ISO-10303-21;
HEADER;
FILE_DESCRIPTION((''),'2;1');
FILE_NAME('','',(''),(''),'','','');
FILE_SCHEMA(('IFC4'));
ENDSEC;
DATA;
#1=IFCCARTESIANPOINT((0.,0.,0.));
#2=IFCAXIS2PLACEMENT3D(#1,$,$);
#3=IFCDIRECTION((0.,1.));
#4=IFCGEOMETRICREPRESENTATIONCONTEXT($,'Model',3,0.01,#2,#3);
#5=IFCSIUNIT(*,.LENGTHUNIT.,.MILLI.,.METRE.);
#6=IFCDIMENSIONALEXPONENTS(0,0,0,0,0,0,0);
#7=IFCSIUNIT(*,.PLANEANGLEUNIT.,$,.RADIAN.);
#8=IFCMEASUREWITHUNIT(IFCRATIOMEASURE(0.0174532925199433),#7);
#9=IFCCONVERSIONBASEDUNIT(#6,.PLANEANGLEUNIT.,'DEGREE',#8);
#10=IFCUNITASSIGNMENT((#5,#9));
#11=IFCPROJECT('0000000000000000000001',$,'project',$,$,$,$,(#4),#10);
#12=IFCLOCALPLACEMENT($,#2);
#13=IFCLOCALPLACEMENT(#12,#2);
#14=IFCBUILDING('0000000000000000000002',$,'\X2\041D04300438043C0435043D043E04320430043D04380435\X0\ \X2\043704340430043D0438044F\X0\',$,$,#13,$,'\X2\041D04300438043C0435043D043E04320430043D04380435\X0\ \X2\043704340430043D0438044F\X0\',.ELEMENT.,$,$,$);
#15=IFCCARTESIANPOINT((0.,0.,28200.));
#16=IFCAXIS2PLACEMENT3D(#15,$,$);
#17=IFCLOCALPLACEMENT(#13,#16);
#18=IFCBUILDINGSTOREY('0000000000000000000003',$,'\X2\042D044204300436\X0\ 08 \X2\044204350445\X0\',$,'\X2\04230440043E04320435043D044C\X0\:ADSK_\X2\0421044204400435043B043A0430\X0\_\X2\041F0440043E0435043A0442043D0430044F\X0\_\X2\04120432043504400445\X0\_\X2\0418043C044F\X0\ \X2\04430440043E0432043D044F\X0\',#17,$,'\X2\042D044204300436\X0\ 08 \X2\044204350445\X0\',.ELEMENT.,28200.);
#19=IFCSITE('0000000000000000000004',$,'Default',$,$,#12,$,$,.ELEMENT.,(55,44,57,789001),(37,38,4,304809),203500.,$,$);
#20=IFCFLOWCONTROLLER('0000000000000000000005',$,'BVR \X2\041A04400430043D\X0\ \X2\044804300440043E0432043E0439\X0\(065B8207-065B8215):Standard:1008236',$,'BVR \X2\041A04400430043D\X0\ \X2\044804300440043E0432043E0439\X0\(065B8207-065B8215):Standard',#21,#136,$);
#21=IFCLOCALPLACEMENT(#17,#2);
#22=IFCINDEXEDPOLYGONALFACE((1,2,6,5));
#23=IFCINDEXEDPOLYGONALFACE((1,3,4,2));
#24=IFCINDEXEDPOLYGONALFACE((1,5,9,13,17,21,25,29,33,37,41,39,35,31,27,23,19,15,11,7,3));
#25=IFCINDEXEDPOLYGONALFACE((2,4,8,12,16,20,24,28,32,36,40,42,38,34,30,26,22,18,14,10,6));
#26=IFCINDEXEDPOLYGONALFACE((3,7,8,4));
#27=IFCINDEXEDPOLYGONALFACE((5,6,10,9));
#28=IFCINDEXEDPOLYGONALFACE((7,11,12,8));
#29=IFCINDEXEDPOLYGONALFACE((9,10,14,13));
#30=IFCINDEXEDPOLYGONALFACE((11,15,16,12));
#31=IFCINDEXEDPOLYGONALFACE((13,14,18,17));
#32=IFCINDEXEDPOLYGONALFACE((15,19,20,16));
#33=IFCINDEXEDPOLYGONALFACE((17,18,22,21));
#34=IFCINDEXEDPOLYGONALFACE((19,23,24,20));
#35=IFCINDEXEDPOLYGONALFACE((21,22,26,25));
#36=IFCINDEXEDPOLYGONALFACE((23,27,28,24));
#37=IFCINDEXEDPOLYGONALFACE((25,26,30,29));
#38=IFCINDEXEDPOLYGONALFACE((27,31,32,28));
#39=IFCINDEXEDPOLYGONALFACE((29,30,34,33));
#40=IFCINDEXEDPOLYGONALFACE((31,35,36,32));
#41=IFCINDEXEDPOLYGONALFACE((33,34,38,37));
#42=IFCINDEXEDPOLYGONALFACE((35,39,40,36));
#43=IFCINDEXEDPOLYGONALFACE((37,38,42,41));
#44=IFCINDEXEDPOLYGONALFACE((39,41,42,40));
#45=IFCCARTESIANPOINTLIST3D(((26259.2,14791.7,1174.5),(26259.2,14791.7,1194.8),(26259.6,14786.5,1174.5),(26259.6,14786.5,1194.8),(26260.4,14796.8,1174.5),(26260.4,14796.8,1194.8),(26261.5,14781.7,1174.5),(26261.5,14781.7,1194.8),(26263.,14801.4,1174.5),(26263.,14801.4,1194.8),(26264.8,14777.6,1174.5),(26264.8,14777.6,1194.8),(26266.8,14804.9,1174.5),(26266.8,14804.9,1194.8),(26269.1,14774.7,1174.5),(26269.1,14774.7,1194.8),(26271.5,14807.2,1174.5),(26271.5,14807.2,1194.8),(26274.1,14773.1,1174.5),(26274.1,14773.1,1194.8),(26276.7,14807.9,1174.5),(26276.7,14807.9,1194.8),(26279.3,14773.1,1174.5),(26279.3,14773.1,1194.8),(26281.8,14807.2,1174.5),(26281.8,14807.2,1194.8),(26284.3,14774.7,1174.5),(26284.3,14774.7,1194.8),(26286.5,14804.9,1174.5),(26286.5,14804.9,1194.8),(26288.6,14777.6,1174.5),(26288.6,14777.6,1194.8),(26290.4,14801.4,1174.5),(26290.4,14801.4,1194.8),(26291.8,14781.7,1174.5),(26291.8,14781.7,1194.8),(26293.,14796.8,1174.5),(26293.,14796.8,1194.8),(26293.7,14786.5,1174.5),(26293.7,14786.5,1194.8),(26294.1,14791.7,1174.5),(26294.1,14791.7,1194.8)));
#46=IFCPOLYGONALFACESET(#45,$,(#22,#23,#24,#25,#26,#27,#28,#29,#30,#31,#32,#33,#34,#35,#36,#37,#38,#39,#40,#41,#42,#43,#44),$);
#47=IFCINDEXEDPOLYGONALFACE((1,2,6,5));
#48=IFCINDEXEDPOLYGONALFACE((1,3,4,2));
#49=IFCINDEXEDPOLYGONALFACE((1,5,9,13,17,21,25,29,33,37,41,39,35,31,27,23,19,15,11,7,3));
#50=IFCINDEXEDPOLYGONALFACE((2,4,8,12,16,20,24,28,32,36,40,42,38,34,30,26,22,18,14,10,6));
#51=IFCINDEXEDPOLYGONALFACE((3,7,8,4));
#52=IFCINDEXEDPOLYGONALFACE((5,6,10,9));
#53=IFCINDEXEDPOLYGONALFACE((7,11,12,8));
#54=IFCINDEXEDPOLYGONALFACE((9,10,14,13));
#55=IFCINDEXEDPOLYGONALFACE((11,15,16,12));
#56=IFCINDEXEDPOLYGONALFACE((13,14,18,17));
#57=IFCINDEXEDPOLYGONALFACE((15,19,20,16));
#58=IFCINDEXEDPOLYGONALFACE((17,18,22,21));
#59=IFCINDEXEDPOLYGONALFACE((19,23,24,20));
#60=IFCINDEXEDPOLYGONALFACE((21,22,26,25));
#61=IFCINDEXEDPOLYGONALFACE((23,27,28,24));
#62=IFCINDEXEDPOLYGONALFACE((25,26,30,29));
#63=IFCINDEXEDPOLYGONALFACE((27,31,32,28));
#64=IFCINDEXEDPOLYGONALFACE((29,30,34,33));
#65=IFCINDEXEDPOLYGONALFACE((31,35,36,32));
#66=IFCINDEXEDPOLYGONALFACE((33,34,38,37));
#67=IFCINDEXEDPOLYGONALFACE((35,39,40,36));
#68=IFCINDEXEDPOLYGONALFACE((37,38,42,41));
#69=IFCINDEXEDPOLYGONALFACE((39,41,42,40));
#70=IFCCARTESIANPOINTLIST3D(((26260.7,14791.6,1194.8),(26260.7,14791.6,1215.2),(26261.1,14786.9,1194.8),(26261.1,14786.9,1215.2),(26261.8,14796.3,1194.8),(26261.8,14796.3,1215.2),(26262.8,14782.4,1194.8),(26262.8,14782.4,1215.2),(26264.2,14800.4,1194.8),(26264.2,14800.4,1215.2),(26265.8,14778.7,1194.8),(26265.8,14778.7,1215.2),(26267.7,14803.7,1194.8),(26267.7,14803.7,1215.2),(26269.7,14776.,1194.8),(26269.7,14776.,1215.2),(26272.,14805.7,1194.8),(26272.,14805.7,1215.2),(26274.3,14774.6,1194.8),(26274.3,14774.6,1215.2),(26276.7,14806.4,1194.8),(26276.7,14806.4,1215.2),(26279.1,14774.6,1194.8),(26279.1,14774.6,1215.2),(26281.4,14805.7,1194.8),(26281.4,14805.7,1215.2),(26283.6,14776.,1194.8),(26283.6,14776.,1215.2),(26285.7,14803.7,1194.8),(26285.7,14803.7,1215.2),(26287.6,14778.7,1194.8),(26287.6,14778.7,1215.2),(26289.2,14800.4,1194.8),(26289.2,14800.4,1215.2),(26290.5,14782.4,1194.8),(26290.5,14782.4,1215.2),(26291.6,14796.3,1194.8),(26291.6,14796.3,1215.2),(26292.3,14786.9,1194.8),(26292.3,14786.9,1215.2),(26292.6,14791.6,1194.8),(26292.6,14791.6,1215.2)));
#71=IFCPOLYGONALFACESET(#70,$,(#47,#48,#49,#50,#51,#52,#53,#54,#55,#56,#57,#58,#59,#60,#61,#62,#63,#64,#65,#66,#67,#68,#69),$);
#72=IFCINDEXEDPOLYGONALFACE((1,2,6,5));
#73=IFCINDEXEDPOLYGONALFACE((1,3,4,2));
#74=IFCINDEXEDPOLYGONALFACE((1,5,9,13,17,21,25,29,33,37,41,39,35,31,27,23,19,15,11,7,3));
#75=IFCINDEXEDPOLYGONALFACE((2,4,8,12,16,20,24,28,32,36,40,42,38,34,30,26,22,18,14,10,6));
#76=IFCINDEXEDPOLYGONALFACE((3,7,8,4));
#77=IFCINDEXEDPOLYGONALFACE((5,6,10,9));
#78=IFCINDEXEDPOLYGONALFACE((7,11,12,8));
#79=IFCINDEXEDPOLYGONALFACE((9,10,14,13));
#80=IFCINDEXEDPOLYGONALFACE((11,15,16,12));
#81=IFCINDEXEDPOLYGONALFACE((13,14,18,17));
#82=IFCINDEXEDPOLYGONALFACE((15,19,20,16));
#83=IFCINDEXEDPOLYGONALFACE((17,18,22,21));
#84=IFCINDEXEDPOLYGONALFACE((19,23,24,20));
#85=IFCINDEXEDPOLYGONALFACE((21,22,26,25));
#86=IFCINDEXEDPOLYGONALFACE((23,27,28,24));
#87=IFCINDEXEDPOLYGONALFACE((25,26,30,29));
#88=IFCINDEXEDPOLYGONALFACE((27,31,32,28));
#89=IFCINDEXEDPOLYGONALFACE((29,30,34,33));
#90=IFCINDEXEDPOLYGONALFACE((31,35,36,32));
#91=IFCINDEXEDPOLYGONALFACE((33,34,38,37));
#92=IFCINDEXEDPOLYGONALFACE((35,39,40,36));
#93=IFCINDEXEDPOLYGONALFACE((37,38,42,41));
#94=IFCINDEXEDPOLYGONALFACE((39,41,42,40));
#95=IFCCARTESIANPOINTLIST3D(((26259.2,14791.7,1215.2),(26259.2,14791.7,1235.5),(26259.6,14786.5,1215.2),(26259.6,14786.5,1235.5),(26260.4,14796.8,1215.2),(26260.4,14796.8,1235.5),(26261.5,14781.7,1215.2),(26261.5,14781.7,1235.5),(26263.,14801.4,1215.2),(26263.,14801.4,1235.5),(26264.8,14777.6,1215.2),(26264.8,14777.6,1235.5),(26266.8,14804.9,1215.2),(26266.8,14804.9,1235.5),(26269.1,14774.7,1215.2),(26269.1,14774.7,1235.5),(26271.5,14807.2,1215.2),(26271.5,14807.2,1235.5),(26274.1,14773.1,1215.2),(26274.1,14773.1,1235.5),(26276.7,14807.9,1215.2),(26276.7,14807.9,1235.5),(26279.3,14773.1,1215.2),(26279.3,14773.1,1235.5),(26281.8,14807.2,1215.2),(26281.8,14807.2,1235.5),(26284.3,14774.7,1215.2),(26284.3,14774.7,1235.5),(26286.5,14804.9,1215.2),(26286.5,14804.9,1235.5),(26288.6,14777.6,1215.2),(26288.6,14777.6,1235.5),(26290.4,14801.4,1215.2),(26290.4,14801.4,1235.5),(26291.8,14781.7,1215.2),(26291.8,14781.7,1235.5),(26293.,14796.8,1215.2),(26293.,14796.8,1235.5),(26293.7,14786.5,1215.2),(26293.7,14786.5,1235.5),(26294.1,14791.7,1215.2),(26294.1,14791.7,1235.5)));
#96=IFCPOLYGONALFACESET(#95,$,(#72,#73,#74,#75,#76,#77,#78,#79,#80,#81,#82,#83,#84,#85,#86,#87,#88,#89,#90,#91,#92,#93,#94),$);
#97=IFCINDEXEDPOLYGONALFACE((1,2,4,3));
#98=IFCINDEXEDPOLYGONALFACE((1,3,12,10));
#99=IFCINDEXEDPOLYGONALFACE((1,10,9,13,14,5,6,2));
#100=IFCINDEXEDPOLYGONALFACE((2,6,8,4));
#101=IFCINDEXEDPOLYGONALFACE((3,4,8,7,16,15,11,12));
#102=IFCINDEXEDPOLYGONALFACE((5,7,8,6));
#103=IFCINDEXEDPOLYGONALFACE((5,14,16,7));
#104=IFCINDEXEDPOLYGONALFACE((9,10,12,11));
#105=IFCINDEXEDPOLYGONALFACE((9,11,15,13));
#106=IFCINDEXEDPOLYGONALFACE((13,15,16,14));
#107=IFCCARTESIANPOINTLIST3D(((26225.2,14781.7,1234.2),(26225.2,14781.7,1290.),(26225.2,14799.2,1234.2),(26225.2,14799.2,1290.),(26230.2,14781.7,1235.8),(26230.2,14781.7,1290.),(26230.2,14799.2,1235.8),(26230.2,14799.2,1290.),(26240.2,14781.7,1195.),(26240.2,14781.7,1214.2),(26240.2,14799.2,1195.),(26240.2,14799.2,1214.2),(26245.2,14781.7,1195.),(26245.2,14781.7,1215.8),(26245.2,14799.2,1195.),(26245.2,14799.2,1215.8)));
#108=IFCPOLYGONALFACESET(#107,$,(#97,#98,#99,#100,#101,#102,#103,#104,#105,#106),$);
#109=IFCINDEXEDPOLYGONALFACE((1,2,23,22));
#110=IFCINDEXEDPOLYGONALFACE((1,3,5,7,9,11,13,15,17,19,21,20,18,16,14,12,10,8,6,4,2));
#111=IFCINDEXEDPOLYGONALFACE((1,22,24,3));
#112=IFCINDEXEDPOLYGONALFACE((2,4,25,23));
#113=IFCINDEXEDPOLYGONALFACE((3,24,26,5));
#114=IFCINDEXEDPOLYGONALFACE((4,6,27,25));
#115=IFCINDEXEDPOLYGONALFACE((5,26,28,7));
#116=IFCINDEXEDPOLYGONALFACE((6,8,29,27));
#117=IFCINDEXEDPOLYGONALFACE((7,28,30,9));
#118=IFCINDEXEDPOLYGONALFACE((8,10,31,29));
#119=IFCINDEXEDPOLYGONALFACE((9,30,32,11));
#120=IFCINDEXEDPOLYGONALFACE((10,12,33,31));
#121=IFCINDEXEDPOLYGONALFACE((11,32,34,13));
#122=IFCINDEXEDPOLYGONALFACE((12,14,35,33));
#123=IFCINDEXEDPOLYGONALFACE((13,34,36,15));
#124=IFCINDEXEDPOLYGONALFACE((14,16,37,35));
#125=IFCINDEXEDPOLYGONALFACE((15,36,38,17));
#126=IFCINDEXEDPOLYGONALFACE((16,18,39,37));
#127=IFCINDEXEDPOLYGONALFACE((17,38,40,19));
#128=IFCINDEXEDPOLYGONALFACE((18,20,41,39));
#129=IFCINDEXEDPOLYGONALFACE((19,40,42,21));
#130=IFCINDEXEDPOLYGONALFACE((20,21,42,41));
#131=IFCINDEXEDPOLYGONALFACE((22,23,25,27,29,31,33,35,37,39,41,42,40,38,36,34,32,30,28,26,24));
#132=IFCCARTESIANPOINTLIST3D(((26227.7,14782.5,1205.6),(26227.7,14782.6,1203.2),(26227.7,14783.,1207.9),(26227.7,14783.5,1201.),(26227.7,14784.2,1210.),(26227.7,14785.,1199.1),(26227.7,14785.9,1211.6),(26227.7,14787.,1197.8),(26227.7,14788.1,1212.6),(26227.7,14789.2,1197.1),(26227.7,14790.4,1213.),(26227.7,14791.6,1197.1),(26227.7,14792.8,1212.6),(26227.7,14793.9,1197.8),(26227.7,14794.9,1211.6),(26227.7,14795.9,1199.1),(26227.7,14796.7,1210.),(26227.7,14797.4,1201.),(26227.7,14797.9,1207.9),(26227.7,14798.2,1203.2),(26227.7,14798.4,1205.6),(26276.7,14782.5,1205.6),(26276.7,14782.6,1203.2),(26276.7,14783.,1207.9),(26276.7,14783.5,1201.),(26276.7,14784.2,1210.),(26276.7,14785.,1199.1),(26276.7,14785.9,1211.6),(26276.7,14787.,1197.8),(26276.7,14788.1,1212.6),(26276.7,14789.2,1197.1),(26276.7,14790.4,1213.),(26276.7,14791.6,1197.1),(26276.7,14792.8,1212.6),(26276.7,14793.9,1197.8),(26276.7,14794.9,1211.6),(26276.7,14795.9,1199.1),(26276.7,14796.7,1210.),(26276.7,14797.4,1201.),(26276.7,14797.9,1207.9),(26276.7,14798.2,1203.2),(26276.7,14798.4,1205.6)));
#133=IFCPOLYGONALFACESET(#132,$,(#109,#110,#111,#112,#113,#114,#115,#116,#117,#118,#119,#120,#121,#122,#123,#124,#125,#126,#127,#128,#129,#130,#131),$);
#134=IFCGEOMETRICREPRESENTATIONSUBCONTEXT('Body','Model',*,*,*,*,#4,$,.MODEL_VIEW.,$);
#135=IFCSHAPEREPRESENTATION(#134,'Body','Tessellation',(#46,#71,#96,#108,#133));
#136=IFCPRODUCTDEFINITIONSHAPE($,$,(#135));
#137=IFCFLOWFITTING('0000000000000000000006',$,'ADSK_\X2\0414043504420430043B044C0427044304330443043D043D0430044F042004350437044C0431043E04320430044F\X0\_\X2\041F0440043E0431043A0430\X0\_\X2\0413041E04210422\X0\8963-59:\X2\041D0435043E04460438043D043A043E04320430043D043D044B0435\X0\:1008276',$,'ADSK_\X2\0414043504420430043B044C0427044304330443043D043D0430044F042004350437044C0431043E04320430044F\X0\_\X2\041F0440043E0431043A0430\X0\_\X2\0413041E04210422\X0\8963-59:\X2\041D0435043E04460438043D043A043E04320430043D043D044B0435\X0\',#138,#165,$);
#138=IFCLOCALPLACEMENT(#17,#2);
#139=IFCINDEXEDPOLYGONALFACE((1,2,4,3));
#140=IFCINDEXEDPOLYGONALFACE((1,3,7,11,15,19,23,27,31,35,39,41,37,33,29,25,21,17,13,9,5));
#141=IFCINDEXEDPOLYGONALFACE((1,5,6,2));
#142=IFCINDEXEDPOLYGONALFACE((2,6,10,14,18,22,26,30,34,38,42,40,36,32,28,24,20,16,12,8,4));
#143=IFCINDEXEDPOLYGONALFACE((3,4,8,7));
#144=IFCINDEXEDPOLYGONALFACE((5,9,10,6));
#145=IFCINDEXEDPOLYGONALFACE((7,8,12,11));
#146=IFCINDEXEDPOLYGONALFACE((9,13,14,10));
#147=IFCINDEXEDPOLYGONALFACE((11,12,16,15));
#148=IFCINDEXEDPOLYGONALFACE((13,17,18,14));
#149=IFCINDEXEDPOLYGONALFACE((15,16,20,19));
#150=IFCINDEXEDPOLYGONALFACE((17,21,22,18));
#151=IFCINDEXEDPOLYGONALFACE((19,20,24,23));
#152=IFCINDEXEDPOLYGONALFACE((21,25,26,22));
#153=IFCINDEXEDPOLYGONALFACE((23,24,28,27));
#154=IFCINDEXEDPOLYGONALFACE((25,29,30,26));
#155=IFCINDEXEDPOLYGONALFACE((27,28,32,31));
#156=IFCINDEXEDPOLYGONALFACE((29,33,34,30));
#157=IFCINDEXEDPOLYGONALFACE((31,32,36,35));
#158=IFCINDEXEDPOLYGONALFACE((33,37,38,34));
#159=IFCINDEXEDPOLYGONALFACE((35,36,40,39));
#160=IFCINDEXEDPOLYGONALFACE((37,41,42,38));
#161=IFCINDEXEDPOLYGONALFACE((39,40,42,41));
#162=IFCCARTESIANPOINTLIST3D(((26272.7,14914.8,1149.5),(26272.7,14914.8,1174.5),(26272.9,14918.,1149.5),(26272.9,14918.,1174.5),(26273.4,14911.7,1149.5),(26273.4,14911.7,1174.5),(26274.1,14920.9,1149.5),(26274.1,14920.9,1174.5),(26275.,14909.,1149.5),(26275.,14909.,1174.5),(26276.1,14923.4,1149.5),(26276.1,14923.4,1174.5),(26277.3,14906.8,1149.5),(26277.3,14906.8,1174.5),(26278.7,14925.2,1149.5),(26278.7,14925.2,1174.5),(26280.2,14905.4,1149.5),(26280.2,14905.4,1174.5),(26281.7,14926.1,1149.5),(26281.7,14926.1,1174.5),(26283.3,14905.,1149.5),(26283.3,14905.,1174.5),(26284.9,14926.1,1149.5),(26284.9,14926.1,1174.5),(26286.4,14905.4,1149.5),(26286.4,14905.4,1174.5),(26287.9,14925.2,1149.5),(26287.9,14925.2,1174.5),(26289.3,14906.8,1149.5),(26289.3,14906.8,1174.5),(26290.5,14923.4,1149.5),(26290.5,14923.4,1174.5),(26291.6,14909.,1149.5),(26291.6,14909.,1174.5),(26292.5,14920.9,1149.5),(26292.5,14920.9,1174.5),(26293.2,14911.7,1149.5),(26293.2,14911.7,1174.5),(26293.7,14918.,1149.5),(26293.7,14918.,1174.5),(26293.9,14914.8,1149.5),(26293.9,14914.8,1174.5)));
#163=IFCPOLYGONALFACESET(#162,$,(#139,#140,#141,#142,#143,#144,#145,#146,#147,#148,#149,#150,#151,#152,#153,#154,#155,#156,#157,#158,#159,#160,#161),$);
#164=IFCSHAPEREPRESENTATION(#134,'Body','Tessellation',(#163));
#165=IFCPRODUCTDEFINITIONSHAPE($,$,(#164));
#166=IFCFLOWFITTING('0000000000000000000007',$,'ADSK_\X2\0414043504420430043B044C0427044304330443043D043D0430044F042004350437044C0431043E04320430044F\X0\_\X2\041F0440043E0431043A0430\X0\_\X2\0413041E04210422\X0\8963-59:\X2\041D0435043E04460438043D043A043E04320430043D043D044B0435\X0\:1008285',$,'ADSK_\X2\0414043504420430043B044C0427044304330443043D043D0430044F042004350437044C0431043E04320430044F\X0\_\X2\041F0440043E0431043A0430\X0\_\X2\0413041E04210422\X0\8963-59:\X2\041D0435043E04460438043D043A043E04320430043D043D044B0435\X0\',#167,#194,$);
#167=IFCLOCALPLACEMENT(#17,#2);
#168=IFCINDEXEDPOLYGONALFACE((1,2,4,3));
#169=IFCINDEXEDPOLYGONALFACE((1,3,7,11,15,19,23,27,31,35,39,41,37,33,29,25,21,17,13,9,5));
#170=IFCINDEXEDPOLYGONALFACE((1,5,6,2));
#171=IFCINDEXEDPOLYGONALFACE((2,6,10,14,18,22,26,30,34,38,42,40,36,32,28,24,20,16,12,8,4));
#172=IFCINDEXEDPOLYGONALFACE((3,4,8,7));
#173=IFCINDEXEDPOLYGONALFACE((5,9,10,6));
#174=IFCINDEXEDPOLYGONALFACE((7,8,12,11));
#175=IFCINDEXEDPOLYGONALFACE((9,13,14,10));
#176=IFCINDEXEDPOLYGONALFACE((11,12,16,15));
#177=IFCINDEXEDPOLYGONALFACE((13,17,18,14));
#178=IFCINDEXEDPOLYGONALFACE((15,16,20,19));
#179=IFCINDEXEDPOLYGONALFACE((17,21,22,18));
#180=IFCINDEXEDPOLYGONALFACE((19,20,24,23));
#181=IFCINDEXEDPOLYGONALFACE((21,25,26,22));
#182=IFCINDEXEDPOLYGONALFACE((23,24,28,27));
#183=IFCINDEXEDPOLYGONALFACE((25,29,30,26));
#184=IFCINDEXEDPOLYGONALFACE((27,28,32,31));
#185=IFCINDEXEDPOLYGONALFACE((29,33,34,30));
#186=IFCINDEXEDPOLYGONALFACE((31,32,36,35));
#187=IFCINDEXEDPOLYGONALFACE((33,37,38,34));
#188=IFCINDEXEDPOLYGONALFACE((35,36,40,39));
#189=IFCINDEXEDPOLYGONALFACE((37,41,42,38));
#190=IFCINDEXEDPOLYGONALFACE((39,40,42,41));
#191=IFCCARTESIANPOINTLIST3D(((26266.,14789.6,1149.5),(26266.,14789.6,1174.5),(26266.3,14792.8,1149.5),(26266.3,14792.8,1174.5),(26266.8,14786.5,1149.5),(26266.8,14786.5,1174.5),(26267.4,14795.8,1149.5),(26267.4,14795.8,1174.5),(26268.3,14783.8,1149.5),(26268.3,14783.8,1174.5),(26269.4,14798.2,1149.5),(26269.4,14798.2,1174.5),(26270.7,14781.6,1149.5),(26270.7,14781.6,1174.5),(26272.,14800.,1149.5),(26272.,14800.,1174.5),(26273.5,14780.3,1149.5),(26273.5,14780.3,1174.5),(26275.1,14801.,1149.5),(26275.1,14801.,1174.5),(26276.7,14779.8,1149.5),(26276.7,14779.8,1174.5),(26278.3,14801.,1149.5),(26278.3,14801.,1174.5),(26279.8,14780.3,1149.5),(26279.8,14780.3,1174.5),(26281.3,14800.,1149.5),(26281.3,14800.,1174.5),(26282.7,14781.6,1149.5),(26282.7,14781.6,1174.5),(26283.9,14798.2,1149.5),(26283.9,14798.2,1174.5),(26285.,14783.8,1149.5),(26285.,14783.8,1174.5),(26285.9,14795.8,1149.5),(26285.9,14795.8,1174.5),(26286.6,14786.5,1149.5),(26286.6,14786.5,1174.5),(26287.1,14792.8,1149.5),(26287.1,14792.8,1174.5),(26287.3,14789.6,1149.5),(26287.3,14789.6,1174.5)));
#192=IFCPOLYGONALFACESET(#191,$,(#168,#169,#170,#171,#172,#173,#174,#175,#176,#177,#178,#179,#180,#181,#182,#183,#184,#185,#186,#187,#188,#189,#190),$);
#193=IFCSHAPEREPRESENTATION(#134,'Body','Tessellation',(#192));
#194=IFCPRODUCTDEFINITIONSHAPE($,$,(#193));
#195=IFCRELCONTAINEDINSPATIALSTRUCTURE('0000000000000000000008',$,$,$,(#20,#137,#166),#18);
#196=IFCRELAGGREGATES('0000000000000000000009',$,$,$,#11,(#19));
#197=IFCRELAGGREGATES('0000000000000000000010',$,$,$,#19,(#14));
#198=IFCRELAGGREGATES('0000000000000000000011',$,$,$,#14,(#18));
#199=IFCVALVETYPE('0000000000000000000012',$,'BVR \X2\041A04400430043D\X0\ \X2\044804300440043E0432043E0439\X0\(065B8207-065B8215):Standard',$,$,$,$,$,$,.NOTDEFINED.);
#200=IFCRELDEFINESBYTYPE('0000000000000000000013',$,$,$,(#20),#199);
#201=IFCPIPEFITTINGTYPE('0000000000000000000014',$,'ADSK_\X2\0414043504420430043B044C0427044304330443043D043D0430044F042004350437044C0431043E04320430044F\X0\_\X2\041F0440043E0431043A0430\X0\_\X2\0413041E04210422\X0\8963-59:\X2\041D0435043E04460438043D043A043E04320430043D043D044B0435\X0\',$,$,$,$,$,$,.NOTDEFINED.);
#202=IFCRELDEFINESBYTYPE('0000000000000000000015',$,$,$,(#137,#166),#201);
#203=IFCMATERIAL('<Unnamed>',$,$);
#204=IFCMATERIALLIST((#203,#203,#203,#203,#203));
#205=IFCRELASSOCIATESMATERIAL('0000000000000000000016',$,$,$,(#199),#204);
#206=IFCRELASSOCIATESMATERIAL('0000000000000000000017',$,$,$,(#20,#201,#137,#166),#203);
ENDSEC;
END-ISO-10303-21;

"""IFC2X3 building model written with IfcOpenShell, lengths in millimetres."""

from ifc_helpers import new_model, entity, si_unit, converted_unit, direction, frame, origin, origin_2d_with_axis, place, context, subcontext, project, spatial, polyline, circle, outline, extrude, source, transform, mapped, material, material_list, type_object, type_shapes, element, save


model = new_model("IFC2X3")

# Units and contexts
model_context = context("Model", 3, precision=0.01, world=origin(), true_north=direction((0.0, 1.0)))
body_context = subcontext(model_context, "Body", "Model", "MODEL_VIEW")
ifc_project = project(units=[si_unit("LENGTHUNIT", "METRE", prefix="MILLI"), converted_unit("PLANEANGLEUNIT", "DEGREE", entity("IfcRatioMeasure", 0.0174532925199433), si_unit("PLANEANGLEUNIT", "RADIAN"), dimensions=[0, 0, 0, 0, 0, 0, 0])], contexts=[model_context])

# Site, building, storey
site_placement = place(None, origin())
site = spatial("IfcSite", under=ifc_project, at=site_placement, Name="Default", CompositionType="ELEMENT", RefLatitude=(55, 44, 57, 789001), RefLongitude=(37, 38, 4, 304809), RefElevation=203500.0)
building_placement = place(site_placement, origin())
building = spatial("IfcBuilding", under=site, at=building_placement, Name="Наименование здания", LongName="Наименование здания", CompositionType="ELEMENT")
storey_placement = place(building_placement, frame((0.0, 0.0, 28200.0)))
storey = spatial("IfcBuildingStorey", under=building, at=storey_placement, Name="Этаж 08 тех", ObjectType="Уровень:ADSK_Стрелка_Проектная_Вверх_Имя уровня", LongName="Этаж 08 тех", CompositionType="ELEMENT", Elevation=28200.0)

# Flow controller
ifc_material = material(Name="<Unnamed>")
ifc_material_list_1 = material_list([ifc_material, ifc_material, ifc_material, ifc_material, ifc_material])
valve_type_1 = type_object("IfcValveType", Name="BVR Кран шаровой(065B8207-065B8215):Standard", PredefinedType="NOTDEFINED", material=ifc_material_list_1)
shared_shape_1 = source(origin(), body_context, "Body", "SweptSolid", [
    extrude(circle(Radius=17.5, at=origin_2d_with_axis()), frame((-30.5, 0.0, 0.0), z_axis=(1.0, 0.0, 0.0), x_axis=(0.0, 1.0, 0.0)), (0.0, 0.0, 1.0), 20.3),
    extrude(circle(Radius=16.0, at=origin_2d_with_axis()), frame((-10.2, 0.0, 0.0), z_axis=(1.0, 0.0, 0.0), x_axis=(0.0, 1.0, 0.0)), (0.0, 0.0, 1.0), 20.3),
    extrude(circle(Radius=17.5, at=origin_2d_with_axis()), frame((10.2, 0.0, 0.0), z_axis=(1.0, 0.0, 0.0), x_axis=(0.0, 1.0, 0.0)), (0.0, 0.0, 1.0), 20.3),
    extrude(outline(polyline([(-38.8, -5.0), (-38.8, -10.0), (-17.9, -10.0), (2.1, 5.0), (56.2, 5.0), (56.2, 10.0), (0.4, 10.0), (-19.6, -5.0), (-38.8, -5.0)])), frame((28.8, -8.8, 41.5), z_axis=(0.0, -1.0, 0.0), x_axis=(1.0, 0.0, 0.0)), (0.0, 0.0, -1.0), 17.5),
    extrude(circle(Radius=8.0, at=origin_2d_with_axis()), origin(), (0.0, 0.0, 1.0), 49.0),
])
type_shapes(valve_type_1, [shared_shape_1])
for number, where, z_axis, x_axis, name in (
    (1, (26276.7, 14790.4, 1205.0), (-1.0, 0.0, 0.0), (0.0, 0.0, 1.0), "BVR Кран шаровой(065B8207-065B8215):Standard:1008236"),
):
    element("IfcFlowController", number, at=place(storey_placement, frame(where, z_axis=z_axis, x_axis=x_axis)), inside=storey, type_object=valve_type_1, material=ifc_material, Name=name, ObjectType="BVR Кран шаровой(065B8207-065B8215):Standard", context=body_context, shape_type="MappedRepresentation", body=[
        mapped(shared_shape_1, transform((0.0, 0.0, 0.0), scale=1.0)),
    ])

# Flow fittings
pipe_fitting_type = type_object("IfcPipeFittingType", Name="ADSK_ДетальЧугуннаяРезьбовая_Пробка_ГОСТ8963-59:Неоцинкованные", PredefinedType="NOTDEFINED", material=ifc_material)
shared_shape_2 = source(origin(), body_context, "Body", "SweptSolid", [
    extrude(circle(Radius=10.7, at=origin_2d_with_axis()), frame((0.0, 0.0, 0.0), z_axis=(1.0, 0.0, 0.0), x_axis=(0.0, 1.0, 0.0)), (0.0, 0.0, 1.0), 25.0),
])
type_shapes(pipe_fitting_type, [shared_shape_2])
for number, where, z_axis, x_axis, name in (
    (2, (26283.3, 14915.6, 1174.5), (-1.0, 0.0, 0.0), (0.0, 0.0, -1.0), "ADSK_ДетальЧугуннаяРезьбовая_Пробка_ГОСТ8963-59:Неоцинкованные:1008276"),
    (3, (26276.7, 14790.4, 1174.5), (-1.0, 0.0, 0.0), (0.0, 0.0, -1.0), "ADSK_ДетальЧугуннаяРезьбовая_Пробка_ГОСТ8963-59:Неоцинкованные:1008285"),
):
    element("IfcFlowFitting", number, at=place(storey_placement, frame(where, z_axis=z_axis, x_axis=x_axis)), inside=storey, type_object=pipe_fitting_type, material=ifc_material, Name=name, ObjectType="ADSK_ДетальЧугуннаяРезьбовая_Пробка_ГОСТ8963-59:Неоцинкованные", context=body_context, shape_type="MappedRepresentation", body=[
        mapped(shared_shape_2, transform((0.0, 0.0, 0.0), scale=1.0)),
    ])

save(model, "model.ifc")
